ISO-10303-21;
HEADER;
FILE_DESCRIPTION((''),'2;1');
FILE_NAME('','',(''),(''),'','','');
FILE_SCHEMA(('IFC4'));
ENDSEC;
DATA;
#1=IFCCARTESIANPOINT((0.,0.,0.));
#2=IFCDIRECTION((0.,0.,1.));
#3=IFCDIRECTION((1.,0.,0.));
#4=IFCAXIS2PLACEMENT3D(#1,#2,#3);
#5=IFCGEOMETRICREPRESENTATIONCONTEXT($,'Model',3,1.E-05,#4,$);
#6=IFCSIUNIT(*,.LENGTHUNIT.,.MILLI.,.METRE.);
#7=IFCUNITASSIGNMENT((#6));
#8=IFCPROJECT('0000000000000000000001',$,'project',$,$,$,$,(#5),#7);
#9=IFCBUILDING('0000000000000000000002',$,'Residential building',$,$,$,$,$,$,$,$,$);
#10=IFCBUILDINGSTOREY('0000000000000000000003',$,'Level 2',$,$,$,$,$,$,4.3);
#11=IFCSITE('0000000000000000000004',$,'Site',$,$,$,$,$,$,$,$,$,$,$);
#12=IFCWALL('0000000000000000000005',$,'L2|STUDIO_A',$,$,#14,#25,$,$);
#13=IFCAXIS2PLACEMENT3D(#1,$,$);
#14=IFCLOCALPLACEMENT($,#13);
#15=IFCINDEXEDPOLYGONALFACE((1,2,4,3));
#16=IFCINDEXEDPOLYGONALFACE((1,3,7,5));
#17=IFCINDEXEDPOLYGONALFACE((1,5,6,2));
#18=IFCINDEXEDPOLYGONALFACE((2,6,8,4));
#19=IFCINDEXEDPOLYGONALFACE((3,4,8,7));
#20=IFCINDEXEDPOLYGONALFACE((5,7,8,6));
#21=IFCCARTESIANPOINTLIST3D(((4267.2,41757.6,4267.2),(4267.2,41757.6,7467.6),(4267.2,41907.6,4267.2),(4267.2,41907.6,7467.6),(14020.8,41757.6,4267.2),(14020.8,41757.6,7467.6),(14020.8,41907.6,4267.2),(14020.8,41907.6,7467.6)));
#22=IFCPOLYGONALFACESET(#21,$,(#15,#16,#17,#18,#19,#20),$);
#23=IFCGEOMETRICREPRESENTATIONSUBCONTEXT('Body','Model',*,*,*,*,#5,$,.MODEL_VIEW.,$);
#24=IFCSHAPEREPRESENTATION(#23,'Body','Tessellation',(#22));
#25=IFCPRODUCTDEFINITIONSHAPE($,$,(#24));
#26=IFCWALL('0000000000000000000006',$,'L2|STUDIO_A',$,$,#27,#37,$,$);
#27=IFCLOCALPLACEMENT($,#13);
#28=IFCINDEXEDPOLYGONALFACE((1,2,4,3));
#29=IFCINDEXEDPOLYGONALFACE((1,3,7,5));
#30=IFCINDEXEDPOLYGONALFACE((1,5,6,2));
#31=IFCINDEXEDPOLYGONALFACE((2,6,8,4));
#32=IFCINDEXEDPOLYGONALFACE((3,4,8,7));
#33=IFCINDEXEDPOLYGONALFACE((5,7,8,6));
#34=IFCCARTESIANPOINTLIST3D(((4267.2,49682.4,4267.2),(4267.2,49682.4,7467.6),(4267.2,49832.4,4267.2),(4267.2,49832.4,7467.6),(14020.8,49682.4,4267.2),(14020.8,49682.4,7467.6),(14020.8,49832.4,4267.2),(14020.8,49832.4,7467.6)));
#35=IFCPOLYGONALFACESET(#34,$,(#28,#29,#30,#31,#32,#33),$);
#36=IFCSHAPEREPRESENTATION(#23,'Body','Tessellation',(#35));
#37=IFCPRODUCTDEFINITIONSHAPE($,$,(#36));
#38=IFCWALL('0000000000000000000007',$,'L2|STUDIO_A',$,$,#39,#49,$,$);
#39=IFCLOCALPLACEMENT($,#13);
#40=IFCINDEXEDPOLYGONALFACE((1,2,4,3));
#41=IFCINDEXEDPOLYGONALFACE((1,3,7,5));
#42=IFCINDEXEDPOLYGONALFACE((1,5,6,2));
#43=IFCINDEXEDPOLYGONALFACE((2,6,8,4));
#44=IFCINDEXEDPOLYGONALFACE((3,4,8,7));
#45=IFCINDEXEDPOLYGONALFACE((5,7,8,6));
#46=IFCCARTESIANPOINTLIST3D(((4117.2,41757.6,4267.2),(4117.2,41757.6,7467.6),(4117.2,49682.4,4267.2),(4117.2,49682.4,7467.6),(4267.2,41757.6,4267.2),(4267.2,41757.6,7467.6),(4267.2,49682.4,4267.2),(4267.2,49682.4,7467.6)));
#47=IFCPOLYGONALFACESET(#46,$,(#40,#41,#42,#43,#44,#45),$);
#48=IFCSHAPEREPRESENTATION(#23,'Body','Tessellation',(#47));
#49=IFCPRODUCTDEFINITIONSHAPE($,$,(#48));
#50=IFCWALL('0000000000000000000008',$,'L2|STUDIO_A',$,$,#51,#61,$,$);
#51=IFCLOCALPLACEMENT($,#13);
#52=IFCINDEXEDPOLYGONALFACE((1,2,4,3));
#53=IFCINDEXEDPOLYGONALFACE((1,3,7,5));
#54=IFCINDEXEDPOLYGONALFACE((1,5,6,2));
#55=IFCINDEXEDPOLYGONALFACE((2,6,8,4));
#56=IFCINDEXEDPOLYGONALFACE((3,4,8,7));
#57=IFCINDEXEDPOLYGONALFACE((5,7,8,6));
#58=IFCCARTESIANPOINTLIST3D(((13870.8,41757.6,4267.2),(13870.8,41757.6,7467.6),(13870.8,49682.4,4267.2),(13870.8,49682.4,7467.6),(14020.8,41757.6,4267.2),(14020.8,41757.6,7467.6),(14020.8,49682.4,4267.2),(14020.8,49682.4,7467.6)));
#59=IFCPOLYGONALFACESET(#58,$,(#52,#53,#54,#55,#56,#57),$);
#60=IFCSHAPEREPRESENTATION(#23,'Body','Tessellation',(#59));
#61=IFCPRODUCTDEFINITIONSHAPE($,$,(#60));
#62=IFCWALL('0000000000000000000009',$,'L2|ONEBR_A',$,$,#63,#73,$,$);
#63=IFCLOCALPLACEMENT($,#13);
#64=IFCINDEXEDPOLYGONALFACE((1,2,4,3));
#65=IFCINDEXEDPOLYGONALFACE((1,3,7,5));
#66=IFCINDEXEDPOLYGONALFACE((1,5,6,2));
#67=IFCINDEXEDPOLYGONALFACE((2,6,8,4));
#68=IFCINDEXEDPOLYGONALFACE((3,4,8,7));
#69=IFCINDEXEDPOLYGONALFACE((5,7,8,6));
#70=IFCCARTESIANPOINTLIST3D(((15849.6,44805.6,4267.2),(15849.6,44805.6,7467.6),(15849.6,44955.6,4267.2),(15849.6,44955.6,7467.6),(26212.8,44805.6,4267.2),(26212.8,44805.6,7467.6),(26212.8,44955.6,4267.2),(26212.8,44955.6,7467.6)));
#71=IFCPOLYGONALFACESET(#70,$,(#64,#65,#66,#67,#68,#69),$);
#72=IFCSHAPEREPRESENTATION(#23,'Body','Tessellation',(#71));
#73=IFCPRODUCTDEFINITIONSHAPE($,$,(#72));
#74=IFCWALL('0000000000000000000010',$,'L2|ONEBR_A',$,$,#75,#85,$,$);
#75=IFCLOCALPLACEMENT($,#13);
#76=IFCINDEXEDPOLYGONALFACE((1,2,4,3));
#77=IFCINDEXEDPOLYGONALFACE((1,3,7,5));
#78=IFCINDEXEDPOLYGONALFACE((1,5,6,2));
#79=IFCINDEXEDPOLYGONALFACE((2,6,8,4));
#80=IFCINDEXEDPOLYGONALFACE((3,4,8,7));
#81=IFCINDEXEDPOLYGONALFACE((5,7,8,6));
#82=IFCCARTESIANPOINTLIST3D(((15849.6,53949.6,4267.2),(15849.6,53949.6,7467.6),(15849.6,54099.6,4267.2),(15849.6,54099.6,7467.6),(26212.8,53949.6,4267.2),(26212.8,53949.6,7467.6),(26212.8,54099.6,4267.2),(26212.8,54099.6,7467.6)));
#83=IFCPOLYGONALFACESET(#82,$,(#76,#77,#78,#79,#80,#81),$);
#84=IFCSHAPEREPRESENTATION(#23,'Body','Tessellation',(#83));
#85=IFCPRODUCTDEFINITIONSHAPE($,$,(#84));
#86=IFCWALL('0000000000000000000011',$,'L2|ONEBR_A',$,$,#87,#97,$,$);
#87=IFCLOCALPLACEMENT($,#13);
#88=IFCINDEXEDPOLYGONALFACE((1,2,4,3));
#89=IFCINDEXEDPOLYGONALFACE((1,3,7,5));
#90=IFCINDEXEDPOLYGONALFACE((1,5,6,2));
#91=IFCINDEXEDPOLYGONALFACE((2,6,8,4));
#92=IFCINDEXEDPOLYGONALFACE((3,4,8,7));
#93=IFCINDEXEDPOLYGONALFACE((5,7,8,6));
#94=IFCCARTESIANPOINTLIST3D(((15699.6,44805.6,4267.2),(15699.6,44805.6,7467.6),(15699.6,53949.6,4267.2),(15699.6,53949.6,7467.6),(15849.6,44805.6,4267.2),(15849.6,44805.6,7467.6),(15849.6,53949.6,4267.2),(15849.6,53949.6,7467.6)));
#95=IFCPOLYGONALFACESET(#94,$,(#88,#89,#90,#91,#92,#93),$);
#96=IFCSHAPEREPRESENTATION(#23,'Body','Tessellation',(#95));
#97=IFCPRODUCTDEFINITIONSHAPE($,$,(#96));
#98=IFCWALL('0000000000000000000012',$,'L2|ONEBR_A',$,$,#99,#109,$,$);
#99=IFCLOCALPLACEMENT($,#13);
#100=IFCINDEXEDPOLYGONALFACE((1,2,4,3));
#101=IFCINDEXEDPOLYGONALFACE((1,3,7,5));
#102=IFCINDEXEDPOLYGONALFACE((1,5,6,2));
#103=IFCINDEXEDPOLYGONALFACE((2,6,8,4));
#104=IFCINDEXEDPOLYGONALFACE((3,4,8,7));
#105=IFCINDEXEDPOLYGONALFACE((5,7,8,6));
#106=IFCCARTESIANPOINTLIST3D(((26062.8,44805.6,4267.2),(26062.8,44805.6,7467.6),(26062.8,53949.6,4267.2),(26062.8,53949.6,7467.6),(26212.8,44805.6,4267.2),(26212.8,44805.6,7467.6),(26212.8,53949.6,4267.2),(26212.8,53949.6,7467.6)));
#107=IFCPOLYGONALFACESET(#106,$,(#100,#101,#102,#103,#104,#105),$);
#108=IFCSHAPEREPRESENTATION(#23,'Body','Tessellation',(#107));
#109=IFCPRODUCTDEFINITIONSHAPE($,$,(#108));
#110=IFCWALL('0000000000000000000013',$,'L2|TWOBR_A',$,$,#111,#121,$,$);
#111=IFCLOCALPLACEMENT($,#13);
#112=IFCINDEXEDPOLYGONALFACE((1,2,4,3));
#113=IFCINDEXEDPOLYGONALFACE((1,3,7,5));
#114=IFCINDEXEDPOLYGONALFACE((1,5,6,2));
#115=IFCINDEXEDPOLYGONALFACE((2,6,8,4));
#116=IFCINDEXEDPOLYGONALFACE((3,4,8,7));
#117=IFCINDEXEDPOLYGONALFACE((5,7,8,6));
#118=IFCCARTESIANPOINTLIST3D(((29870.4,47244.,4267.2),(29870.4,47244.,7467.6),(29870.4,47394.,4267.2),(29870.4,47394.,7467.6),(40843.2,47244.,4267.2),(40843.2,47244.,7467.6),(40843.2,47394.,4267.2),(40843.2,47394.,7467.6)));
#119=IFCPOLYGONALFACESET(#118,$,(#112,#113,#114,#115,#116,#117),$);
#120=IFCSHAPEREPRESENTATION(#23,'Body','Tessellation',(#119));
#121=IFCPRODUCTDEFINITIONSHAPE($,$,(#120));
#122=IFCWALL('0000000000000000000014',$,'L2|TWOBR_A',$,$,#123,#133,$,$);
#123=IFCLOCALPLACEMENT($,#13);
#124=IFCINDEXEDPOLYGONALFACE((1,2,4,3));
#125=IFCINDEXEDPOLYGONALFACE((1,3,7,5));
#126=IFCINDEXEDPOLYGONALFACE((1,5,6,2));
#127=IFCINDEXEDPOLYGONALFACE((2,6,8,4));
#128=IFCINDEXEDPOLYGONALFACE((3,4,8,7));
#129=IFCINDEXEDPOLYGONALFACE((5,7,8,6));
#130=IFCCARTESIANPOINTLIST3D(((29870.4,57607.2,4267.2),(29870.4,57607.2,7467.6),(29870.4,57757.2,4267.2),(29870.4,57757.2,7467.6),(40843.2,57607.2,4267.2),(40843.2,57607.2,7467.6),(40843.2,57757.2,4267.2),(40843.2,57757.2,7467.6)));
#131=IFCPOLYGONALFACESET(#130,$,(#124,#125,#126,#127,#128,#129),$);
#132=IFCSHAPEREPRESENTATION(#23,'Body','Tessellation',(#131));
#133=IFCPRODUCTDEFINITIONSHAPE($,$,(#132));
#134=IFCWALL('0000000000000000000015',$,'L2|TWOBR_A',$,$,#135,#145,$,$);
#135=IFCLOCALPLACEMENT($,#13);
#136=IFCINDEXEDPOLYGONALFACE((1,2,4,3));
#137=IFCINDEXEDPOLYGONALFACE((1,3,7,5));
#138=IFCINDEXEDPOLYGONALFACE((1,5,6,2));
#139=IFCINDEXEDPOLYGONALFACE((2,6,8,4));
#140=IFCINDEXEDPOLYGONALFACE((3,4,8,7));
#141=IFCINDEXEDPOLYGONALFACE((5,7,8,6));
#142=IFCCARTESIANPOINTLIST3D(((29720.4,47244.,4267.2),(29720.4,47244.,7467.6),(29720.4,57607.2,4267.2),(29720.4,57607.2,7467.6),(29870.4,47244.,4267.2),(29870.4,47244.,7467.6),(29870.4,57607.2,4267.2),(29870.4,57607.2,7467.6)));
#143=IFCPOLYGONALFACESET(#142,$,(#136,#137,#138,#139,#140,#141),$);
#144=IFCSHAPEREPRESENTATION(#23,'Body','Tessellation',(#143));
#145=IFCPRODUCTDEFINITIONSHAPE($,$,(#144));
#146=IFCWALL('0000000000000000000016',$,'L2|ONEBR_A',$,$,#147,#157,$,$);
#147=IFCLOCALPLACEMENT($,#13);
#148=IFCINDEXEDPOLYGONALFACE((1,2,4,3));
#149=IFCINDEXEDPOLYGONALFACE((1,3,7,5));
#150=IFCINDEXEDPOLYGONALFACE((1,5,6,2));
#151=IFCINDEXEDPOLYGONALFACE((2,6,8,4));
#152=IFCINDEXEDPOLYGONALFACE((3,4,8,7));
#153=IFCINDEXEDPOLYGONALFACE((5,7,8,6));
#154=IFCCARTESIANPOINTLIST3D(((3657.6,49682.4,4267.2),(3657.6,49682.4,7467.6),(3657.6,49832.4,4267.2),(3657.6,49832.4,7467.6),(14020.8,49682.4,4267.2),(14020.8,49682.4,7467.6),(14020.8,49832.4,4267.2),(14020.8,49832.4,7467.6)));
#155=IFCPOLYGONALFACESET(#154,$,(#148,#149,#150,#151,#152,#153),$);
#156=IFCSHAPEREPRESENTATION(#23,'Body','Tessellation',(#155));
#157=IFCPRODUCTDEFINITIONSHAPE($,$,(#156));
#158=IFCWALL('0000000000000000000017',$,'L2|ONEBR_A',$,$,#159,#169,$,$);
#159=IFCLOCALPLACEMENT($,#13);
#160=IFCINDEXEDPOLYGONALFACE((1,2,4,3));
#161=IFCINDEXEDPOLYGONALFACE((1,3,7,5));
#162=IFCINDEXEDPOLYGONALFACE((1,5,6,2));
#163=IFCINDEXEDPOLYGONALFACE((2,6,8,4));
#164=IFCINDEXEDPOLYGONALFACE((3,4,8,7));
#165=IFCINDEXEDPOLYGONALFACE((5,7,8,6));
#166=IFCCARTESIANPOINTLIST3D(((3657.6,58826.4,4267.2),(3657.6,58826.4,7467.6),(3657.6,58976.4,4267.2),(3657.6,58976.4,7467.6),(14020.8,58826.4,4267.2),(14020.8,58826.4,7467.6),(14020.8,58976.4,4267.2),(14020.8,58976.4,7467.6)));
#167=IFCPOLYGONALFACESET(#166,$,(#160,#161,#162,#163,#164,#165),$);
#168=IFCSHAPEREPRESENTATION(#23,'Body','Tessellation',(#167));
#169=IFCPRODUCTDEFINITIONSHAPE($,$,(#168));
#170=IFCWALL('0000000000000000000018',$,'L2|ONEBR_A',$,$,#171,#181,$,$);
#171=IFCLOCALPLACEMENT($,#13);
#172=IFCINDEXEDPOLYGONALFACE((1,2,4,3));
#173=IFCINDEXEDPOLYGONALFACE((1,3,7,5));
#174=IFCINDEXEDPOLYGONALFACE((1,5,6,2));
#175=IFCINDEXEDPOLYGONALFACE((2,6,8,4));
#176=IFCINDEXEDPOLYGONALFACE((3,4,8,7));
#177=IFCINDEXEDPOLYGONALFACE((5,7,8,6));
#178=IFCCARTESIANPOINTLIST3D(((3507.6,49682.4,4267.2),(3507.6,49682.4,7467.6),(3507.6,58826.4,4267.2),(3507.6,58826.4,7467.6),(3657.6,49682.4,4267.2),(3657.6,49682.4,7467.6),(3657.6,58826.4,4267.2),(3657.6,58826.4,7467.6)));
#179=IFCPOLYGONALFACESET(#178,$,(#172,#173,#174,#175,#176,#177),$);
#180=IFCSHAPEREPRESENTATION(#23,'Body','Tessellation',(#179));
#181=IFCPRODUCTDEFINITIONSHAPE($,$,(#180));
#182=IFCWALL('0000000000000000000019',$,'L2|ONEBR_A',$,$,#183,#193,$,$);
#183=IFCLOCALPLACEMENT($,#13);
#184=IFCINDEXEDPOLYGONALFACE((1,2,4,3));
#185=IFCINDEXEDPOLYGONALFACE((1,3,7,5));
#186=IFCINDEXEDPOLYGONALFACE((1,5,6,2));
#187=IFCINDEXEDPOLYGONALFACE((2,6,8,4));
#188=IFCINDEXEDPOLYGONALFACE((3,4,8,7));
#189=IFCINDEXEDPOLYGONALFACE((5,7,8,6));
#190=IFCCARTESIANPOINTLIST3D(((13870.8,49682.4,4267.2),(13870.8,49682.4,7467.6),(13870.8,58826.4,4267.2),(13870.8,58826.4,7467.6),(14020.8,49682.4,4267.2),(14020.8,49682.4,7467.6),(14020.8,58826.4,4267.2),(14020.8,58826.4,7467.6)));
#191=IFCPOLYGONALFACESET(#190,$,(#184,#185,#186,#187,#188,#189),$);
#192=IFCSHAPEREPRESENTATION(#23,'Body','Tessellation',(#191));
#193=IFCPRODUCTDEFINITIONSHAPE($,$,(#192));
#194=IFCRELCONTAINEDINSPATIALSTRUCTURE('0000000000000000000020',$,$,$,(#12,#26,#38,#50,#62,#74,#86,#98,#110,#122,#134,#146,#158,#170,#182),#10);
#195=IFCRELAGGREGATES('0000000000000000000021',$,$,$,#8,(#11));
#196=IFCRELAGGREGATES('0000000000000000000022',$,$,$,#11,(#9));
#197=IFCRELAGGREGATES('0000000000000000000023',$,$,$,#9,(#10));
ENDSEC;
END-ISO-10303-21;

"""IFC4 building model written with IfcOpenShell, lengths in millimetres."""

from ifc_helpers import new_model, si_unit, frame, origin_with_axes, place, context, subcontext, project, spatial, indexed_curve, outline, extrude, element, save


model = new_model("IFC4")

# Units and contexts
model_context = context("Model", 3, precision=1e-05, world=origin_with_axes())
body_context = subcontext(model_context, "Body", "Model", "MODEL_VIEW")
ifc_project = project(units=[si_unit("LENGTHUNIT", "METRE", prefix="MILLI")], contexts=[model_context])

# Site, building, storey
site = spatial("IfcSite", under=ifc_project, Name="Site")
building = spatial("IfcBuilding", under=site, Name="Residential building")
storey = spatial("IfcBuildingStorey", under=building, Name="Level 2", Elevation=4.3)

# Walls
for number, where, z_axis, x_axis, name in (
    (1, (4267.2, 41757.6, 4267.2), (0.0, 0.0, 1.0), (1.0, 0.0, 0.0), "L2|STUDIO_A"),
    (2, (4267.2, 49682.4, 4267.2), (0.0, 0.0, 1.0), (1.0, 0.0, 0.0), "L2|STUDIO_A"),
):
    element("IfcWall", number, at=place(None, frame(where, z_axis=z_axis, x_axis=x_axis)), inside=storey, Name=name, context=body_context, shape_type="SweptSolid", body=[
        extrude(outline(indexed_curve([(0.0, 0.0), (0.0, 150.0), (9753.6, 150.0), (9753.6, 0.0), (0.0, 0.0)], self_intersect=False)), origin_with_axes(), (0.0, 0.0, 1.0), 3200.4),
    ])
for number, where, z_axis, x_axis, name in (
    (3, (4267.2, 41757.6, 4267.2), (0.0, 0.0, 1.0), (0.0, 1.0, 0.0), "L2|STUDIO_A"),
    (4, (14020.8, 41757.6, 4267.2), (0.0, 0.0, 1.0), (0.0, 1.0, 0.0), "L2|STUDIO_A"),
):
    element("IfcWall", number, at=place(None, frame(where, z_axis=z_axis, x_axis=x_axis)), inside=storey, Name=name, context=body_context, shape_type="SweptSolid", body=[
        extrude(outline(indexed_curve([(0.0, 0.0), (0.0, 150.0), (7924.8, 150.0), (7924.8, 0.0), (0.0, 0.0)], self_intersect=False)), origin_with_axes(), (0.0, 0.0, 1.0), 3200.4),
    ])
for number, where, z_axis, x_axis, name in (
    (5, (15849.6, 44805.6, 4267.2), (0.0, 0.0, 1.0), (1.0, 0.0, 0.0), "L2|ONEBR_A"),
    (6, (15849.6, 53949.6, 4267.2), (0.0, 0.0, 1.0), (1.0, 0.0, 0.0), "L2|ONEBR_A"),
):
    element("IfcWall", number, at=place(None, frame(where, z_axis=z_axis, x_axis=x_axis)), inside=storey, Name=name, context=body_context, shape_type="SweptSolid", body=[
        extrude(outline(indexed_curve([(0.0, 0.0), (0.0, 150.0), (10363.2, 150.0), (10363.2, 0.0), (0.0, 0.0)], self_intersect=False)), origin_with_axes(), (0.0, 0.0, 1.0), 3200.4),
    ])
for number, where, z_axis, x_axis, name in (
    (7, (15849.6, 44805.6, 4267.2), (0.0, 0.0, 1.0), (0.0, 1.0, 0.0), "L2|ONEBR_A"),
    (8, (26212.8, 44805.6, 4267.2), (0.0, 0.0, 1.0), (0.0, 1.0, 0.0), "L2|ONEBR_A"),
):
    element("IfcWall", number, at=place(None, frame(where, z_axis=z_axis, x_axis=x_axis)), inside=storey, Name=name, context=body_context, shape_type="SweptSolid", body=[
        extrude(outline(indexed_curve([(0.0, 0.0), (0.0, 150.0), (9144.0, 150.0), (9144.0, 0.0), (0.0, 0.0)], self_intersect=False)), origin_with_axes(), (0.0, 0.0, 1.0), 3200.4),
    ])
for number, where, z_axis, x_axis, name in (
    (9, (29870.4, 47244.0, 4267.2), (0.0, 0.0, 1.0), (1.0, 0.0, 0.0), "L2|TWOBR_A"),
    (10, (29870.4, 57607.2, 4267.2), (0.0, 0.0, 1.0), (1.0, 0.0, 0.0), "L2|TWOBR_A"),
):
    element("IfcWall", number, at=place(None, frame(where, z_axis=z_axis, x_axis=x_axis)), inside=storey, Name=name, context=body_context, shape_type="SweptSolid", body=[
        extrude(outline(indexed_curve([(0.0, 0.0), (0.0, 150.0), (10972.8, 150.0), (10972.8, 0.0), (0.0, 0.0)], self_intersect=False)), origin_with_axes(), (0.0, 0.0, 1.0), 3200.4),
    ])
for number, where, z_axis, x_axis, name in (
    (11, (29870.4, 47244.0, 4267.2), (0.0, 0.0, 1.0), (0.0, 1.0, 0.0), "L2|TWOBR_A"),
    (12, (3657.6, 49682.4, 4267.2), (0.0, 0.0, 1.0), (1.0, 0.0, 0.0), "L2|ONEBR_A"),
    (13, (3657.6, 58826.4, 4267.2), (0.0, 0.0, 1.0), (1.0, 0.0, 0.0), "L2|ONEBR_A"),
):
    element("IfcWall", number, at=place(None, frame(where, z_axis=z_axis, x_axis=x_axis)), inside=storey, Name=name, context=body_context, shape_type="SweptSolid", body=[
        extrude(outline(indexed_curve([(0.0, 0.0), (0.0, 150.0), (10363.2, 150.0), (10363.2, 0.0), (0.0, 0.0)], self_intersect=False)), origin_with_axes(), (0.0, 0.0, 1.0), 3200.4),
    ])
for number, where, z_axis, x_axis, name in (
    (14, (3657.6, 49682.4, 4267.2), (0.0, 0.0, 1.0), (0.0, 1.0, 0.0), "L2|ONEBR_A"),
    (15, (14020.8, 49682.4, 4267.2), (0.0, 0.0, 1.0), (0.0, 1.0, 0.0), "L2|ONEBR_A"),
):
    element("IfcWall", number, at=place(None, frame(where, z_axis=z_axis, x_axis=x_axis)), inside=storey, Name=name, context=body_context, shape_type="SweptSolid", body=[
        extrude(outline(indexed_curve([(0.0, 0.0), (0.0, 150.0), (9144.0, 150.0), (9144.0, 0.0), (0.0, 0.0)], self_intersect=False)), origin_with_axes(), (0.0, 0.0, 1.0), 3200.4),
    ])

save(model, "model.ifc")
